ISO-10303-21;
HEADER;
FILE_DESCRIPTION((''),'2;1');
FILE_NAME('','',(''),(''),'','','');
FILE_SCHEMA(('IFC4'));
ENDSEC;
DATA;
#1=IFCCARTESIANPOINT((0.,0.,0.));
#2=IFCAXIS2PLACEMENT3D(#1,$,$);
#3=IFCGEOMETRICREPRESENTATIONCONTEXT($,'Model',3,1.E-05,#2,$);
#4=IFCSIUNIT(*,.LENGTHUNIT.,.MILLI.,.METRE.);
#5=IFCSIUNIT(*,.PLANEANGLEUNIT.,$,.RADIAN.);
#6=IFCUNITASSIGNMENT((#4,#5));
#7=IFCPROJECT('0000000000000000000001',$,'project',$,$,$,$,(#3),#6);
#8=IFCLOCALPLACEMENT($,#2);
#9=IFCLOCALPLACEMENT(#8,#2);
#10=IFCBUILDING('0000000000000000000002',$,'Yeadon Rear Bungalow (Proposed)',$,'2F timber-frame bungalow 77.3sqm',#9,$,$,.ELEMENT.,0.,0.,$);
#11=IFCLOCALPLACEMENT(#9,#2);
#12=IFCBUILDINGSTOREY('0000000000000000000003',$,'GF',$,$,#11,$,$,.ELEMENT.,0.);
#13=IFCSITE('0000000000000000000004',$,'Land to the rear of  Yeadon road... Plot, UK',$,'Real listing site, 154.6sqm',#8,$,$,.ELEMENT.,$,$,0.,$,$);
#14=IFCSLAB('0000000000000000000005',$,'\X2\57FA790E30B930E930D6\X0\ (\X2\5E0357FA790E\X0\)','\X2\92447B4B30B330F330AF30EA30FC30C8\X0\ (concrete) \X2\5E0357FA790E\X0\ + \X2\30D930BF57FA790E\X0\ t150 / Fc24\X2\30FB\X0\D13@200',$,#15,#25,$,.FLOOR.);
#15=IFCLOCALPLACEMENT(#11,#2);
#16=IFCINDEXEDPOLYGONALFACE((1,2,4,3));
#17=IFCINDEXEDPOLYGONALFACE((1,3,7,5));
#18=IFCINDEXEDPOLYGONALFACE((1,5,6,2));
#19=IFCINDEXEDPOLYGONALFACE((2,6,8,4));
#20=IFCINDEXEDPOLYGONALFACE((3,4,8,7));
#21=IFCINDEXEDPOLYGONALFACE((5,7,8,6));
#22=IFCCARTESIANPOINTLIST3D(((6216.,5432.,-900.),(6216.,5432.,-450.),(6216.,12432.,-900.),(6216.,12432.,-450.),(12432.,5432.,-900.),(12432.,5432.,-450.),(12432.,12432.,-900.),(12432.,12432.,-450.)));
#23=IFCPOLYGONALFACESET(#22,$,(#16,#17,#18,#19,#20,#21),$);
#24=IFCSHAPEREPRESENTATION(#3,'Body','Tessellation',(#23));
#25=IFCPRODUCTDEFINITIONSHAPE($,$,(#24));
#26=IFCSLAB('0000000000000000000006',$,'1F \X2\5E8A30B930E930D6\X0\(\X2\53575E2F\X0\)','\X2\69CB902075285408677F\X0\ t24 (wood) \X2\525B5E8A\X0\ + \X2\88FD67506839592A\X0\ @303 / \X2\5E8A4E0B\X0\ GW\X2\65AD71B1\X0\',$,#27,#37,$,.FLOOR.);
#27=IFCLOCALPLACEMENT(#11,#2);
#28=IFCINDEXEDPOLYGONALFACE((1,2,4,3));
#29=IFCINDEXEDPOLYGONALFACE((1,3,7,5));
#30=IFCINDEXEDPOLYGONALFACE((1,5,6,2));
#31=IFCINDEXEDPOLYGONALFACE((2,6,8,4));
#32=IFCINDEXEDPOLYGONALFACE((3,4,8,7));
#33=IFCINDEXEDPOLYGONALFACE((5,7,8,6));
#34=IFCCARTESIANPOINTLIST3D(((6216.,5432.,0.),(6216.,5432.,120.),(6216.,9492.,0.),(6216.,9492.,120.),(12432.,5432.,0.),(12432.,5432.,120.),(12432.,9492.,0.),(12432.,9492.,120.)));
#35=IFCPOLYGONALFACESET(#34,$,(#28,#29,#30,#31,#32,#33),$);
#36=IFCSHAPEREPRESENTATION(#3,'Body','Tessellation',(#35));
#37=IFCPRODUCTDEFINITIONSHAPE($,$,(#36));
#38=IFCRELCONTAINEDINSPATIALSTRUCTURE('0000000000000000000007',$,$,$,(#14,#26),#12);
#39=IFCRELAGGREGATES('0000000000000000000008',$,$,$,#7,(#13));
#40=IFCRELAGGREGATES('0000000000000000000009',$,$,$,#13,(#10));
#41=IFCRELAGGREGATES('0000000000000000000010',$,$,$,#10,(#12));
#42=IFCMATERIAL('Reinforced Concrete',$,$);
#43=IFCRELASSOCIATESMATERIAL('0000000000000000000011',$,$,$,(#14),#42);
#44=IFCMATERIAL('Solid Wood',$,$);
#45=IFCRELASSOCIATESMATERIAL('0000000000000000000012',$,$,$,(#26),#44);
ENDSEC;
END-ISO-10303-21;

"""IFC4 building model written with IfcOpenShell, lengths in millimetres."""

from ifc_helpers import new_model, si_unit, frame, frame_2d, origin, place, context, project, spatial, rectangle, extrude, material, element, save


model = new_model("IFC4")

# Units and contexts
model_context = context("Model", 3, precision=1e-05, world=origin())
ifc_project = project(units=[si_unit("LENGTHUNIT", "METRE", prefix="MILLI"), si_unit("PLANEANGLEUNIT", "RADIAN")], contexts=[model_context])

# Site, building, storey
site_placement = place(None, origin())
site = spatial("IfcSite", under=ifc_project, at=site_placement, Name="Land to the rear of  Yeadon road... Plot, UK", ObjectType="Real listing site, 154.6sqm", CompositionType="ELEMENT", RefElevation=0.0)
building_placement = place(site_placement, origin())
building = spatial("IfcBuilding", under=site, at=building_placement, Name="Yeadon Rear Bungalow (Proposed)", ObjectType="2F timber-frame bungalow 77.3sqm", CompositionType="ELEMENT", ElevationOfRefHeight=0.0, ElevationOfTerrain=0.0)
storey_placement = place(building_placement, origin())
storey = spatial("IfcBuildingStorey", under=building, at=storey_placement, Name="GF", CompositionType="ELEMENT", Elevation=0.0)

# Slabs
ifc_material_1 = material(Name="Reinforced Concrete")
slab_1_placement = place(storey_placement, frame((3108.0, 2716.0, -450.0)))
element("IfcSlab", 1, at=slab_1_placement, inside=storey, material=ifc_material_1, Name="基礎スラブ (布基礎)", Description="鉄筋コンクリート (concrete) 布基礎 + ベタ基礎 t150 / Fc24・D13@200", PredefinedType="FLOOR", context=model_context, shape_type="SweptSolid", body=[
    extrude(rectangle(XDim=6216.0, YDim=7000.0, at=frame_2d((3108.0, 3500.0))), frame((3108.0, 2716.0, -450.0)), (0.0, 0.0, 1.0), 450.0),
])
ifc_material_2 = material(Name="Solid Wood")
slab_2_placement = place(storey_placement, frame((3108.0, 2716.0, 0.0)))
element("IfcSlab", 2, at=slab_2_placement, inside=storey, material=ifc_material_2, Name="1F 床スラブ(南帯)", Description="構造用合板 t24 (wood) 剛床 + 製材根太 @303 / 床下 GW断熱", PredefinedType="FLOOR", context=model_context, shape_type="SweptSolid", body=[
    extrude(rectangle(XDim=6216.0, YDim=4060.0, at=frame_2d((3108.0, 2030.0))), frame((3108.0, 2716.0, 0.0)), (0.0, 0.0, 1.0), 120.0),
])

save(model, "model.ifc")
